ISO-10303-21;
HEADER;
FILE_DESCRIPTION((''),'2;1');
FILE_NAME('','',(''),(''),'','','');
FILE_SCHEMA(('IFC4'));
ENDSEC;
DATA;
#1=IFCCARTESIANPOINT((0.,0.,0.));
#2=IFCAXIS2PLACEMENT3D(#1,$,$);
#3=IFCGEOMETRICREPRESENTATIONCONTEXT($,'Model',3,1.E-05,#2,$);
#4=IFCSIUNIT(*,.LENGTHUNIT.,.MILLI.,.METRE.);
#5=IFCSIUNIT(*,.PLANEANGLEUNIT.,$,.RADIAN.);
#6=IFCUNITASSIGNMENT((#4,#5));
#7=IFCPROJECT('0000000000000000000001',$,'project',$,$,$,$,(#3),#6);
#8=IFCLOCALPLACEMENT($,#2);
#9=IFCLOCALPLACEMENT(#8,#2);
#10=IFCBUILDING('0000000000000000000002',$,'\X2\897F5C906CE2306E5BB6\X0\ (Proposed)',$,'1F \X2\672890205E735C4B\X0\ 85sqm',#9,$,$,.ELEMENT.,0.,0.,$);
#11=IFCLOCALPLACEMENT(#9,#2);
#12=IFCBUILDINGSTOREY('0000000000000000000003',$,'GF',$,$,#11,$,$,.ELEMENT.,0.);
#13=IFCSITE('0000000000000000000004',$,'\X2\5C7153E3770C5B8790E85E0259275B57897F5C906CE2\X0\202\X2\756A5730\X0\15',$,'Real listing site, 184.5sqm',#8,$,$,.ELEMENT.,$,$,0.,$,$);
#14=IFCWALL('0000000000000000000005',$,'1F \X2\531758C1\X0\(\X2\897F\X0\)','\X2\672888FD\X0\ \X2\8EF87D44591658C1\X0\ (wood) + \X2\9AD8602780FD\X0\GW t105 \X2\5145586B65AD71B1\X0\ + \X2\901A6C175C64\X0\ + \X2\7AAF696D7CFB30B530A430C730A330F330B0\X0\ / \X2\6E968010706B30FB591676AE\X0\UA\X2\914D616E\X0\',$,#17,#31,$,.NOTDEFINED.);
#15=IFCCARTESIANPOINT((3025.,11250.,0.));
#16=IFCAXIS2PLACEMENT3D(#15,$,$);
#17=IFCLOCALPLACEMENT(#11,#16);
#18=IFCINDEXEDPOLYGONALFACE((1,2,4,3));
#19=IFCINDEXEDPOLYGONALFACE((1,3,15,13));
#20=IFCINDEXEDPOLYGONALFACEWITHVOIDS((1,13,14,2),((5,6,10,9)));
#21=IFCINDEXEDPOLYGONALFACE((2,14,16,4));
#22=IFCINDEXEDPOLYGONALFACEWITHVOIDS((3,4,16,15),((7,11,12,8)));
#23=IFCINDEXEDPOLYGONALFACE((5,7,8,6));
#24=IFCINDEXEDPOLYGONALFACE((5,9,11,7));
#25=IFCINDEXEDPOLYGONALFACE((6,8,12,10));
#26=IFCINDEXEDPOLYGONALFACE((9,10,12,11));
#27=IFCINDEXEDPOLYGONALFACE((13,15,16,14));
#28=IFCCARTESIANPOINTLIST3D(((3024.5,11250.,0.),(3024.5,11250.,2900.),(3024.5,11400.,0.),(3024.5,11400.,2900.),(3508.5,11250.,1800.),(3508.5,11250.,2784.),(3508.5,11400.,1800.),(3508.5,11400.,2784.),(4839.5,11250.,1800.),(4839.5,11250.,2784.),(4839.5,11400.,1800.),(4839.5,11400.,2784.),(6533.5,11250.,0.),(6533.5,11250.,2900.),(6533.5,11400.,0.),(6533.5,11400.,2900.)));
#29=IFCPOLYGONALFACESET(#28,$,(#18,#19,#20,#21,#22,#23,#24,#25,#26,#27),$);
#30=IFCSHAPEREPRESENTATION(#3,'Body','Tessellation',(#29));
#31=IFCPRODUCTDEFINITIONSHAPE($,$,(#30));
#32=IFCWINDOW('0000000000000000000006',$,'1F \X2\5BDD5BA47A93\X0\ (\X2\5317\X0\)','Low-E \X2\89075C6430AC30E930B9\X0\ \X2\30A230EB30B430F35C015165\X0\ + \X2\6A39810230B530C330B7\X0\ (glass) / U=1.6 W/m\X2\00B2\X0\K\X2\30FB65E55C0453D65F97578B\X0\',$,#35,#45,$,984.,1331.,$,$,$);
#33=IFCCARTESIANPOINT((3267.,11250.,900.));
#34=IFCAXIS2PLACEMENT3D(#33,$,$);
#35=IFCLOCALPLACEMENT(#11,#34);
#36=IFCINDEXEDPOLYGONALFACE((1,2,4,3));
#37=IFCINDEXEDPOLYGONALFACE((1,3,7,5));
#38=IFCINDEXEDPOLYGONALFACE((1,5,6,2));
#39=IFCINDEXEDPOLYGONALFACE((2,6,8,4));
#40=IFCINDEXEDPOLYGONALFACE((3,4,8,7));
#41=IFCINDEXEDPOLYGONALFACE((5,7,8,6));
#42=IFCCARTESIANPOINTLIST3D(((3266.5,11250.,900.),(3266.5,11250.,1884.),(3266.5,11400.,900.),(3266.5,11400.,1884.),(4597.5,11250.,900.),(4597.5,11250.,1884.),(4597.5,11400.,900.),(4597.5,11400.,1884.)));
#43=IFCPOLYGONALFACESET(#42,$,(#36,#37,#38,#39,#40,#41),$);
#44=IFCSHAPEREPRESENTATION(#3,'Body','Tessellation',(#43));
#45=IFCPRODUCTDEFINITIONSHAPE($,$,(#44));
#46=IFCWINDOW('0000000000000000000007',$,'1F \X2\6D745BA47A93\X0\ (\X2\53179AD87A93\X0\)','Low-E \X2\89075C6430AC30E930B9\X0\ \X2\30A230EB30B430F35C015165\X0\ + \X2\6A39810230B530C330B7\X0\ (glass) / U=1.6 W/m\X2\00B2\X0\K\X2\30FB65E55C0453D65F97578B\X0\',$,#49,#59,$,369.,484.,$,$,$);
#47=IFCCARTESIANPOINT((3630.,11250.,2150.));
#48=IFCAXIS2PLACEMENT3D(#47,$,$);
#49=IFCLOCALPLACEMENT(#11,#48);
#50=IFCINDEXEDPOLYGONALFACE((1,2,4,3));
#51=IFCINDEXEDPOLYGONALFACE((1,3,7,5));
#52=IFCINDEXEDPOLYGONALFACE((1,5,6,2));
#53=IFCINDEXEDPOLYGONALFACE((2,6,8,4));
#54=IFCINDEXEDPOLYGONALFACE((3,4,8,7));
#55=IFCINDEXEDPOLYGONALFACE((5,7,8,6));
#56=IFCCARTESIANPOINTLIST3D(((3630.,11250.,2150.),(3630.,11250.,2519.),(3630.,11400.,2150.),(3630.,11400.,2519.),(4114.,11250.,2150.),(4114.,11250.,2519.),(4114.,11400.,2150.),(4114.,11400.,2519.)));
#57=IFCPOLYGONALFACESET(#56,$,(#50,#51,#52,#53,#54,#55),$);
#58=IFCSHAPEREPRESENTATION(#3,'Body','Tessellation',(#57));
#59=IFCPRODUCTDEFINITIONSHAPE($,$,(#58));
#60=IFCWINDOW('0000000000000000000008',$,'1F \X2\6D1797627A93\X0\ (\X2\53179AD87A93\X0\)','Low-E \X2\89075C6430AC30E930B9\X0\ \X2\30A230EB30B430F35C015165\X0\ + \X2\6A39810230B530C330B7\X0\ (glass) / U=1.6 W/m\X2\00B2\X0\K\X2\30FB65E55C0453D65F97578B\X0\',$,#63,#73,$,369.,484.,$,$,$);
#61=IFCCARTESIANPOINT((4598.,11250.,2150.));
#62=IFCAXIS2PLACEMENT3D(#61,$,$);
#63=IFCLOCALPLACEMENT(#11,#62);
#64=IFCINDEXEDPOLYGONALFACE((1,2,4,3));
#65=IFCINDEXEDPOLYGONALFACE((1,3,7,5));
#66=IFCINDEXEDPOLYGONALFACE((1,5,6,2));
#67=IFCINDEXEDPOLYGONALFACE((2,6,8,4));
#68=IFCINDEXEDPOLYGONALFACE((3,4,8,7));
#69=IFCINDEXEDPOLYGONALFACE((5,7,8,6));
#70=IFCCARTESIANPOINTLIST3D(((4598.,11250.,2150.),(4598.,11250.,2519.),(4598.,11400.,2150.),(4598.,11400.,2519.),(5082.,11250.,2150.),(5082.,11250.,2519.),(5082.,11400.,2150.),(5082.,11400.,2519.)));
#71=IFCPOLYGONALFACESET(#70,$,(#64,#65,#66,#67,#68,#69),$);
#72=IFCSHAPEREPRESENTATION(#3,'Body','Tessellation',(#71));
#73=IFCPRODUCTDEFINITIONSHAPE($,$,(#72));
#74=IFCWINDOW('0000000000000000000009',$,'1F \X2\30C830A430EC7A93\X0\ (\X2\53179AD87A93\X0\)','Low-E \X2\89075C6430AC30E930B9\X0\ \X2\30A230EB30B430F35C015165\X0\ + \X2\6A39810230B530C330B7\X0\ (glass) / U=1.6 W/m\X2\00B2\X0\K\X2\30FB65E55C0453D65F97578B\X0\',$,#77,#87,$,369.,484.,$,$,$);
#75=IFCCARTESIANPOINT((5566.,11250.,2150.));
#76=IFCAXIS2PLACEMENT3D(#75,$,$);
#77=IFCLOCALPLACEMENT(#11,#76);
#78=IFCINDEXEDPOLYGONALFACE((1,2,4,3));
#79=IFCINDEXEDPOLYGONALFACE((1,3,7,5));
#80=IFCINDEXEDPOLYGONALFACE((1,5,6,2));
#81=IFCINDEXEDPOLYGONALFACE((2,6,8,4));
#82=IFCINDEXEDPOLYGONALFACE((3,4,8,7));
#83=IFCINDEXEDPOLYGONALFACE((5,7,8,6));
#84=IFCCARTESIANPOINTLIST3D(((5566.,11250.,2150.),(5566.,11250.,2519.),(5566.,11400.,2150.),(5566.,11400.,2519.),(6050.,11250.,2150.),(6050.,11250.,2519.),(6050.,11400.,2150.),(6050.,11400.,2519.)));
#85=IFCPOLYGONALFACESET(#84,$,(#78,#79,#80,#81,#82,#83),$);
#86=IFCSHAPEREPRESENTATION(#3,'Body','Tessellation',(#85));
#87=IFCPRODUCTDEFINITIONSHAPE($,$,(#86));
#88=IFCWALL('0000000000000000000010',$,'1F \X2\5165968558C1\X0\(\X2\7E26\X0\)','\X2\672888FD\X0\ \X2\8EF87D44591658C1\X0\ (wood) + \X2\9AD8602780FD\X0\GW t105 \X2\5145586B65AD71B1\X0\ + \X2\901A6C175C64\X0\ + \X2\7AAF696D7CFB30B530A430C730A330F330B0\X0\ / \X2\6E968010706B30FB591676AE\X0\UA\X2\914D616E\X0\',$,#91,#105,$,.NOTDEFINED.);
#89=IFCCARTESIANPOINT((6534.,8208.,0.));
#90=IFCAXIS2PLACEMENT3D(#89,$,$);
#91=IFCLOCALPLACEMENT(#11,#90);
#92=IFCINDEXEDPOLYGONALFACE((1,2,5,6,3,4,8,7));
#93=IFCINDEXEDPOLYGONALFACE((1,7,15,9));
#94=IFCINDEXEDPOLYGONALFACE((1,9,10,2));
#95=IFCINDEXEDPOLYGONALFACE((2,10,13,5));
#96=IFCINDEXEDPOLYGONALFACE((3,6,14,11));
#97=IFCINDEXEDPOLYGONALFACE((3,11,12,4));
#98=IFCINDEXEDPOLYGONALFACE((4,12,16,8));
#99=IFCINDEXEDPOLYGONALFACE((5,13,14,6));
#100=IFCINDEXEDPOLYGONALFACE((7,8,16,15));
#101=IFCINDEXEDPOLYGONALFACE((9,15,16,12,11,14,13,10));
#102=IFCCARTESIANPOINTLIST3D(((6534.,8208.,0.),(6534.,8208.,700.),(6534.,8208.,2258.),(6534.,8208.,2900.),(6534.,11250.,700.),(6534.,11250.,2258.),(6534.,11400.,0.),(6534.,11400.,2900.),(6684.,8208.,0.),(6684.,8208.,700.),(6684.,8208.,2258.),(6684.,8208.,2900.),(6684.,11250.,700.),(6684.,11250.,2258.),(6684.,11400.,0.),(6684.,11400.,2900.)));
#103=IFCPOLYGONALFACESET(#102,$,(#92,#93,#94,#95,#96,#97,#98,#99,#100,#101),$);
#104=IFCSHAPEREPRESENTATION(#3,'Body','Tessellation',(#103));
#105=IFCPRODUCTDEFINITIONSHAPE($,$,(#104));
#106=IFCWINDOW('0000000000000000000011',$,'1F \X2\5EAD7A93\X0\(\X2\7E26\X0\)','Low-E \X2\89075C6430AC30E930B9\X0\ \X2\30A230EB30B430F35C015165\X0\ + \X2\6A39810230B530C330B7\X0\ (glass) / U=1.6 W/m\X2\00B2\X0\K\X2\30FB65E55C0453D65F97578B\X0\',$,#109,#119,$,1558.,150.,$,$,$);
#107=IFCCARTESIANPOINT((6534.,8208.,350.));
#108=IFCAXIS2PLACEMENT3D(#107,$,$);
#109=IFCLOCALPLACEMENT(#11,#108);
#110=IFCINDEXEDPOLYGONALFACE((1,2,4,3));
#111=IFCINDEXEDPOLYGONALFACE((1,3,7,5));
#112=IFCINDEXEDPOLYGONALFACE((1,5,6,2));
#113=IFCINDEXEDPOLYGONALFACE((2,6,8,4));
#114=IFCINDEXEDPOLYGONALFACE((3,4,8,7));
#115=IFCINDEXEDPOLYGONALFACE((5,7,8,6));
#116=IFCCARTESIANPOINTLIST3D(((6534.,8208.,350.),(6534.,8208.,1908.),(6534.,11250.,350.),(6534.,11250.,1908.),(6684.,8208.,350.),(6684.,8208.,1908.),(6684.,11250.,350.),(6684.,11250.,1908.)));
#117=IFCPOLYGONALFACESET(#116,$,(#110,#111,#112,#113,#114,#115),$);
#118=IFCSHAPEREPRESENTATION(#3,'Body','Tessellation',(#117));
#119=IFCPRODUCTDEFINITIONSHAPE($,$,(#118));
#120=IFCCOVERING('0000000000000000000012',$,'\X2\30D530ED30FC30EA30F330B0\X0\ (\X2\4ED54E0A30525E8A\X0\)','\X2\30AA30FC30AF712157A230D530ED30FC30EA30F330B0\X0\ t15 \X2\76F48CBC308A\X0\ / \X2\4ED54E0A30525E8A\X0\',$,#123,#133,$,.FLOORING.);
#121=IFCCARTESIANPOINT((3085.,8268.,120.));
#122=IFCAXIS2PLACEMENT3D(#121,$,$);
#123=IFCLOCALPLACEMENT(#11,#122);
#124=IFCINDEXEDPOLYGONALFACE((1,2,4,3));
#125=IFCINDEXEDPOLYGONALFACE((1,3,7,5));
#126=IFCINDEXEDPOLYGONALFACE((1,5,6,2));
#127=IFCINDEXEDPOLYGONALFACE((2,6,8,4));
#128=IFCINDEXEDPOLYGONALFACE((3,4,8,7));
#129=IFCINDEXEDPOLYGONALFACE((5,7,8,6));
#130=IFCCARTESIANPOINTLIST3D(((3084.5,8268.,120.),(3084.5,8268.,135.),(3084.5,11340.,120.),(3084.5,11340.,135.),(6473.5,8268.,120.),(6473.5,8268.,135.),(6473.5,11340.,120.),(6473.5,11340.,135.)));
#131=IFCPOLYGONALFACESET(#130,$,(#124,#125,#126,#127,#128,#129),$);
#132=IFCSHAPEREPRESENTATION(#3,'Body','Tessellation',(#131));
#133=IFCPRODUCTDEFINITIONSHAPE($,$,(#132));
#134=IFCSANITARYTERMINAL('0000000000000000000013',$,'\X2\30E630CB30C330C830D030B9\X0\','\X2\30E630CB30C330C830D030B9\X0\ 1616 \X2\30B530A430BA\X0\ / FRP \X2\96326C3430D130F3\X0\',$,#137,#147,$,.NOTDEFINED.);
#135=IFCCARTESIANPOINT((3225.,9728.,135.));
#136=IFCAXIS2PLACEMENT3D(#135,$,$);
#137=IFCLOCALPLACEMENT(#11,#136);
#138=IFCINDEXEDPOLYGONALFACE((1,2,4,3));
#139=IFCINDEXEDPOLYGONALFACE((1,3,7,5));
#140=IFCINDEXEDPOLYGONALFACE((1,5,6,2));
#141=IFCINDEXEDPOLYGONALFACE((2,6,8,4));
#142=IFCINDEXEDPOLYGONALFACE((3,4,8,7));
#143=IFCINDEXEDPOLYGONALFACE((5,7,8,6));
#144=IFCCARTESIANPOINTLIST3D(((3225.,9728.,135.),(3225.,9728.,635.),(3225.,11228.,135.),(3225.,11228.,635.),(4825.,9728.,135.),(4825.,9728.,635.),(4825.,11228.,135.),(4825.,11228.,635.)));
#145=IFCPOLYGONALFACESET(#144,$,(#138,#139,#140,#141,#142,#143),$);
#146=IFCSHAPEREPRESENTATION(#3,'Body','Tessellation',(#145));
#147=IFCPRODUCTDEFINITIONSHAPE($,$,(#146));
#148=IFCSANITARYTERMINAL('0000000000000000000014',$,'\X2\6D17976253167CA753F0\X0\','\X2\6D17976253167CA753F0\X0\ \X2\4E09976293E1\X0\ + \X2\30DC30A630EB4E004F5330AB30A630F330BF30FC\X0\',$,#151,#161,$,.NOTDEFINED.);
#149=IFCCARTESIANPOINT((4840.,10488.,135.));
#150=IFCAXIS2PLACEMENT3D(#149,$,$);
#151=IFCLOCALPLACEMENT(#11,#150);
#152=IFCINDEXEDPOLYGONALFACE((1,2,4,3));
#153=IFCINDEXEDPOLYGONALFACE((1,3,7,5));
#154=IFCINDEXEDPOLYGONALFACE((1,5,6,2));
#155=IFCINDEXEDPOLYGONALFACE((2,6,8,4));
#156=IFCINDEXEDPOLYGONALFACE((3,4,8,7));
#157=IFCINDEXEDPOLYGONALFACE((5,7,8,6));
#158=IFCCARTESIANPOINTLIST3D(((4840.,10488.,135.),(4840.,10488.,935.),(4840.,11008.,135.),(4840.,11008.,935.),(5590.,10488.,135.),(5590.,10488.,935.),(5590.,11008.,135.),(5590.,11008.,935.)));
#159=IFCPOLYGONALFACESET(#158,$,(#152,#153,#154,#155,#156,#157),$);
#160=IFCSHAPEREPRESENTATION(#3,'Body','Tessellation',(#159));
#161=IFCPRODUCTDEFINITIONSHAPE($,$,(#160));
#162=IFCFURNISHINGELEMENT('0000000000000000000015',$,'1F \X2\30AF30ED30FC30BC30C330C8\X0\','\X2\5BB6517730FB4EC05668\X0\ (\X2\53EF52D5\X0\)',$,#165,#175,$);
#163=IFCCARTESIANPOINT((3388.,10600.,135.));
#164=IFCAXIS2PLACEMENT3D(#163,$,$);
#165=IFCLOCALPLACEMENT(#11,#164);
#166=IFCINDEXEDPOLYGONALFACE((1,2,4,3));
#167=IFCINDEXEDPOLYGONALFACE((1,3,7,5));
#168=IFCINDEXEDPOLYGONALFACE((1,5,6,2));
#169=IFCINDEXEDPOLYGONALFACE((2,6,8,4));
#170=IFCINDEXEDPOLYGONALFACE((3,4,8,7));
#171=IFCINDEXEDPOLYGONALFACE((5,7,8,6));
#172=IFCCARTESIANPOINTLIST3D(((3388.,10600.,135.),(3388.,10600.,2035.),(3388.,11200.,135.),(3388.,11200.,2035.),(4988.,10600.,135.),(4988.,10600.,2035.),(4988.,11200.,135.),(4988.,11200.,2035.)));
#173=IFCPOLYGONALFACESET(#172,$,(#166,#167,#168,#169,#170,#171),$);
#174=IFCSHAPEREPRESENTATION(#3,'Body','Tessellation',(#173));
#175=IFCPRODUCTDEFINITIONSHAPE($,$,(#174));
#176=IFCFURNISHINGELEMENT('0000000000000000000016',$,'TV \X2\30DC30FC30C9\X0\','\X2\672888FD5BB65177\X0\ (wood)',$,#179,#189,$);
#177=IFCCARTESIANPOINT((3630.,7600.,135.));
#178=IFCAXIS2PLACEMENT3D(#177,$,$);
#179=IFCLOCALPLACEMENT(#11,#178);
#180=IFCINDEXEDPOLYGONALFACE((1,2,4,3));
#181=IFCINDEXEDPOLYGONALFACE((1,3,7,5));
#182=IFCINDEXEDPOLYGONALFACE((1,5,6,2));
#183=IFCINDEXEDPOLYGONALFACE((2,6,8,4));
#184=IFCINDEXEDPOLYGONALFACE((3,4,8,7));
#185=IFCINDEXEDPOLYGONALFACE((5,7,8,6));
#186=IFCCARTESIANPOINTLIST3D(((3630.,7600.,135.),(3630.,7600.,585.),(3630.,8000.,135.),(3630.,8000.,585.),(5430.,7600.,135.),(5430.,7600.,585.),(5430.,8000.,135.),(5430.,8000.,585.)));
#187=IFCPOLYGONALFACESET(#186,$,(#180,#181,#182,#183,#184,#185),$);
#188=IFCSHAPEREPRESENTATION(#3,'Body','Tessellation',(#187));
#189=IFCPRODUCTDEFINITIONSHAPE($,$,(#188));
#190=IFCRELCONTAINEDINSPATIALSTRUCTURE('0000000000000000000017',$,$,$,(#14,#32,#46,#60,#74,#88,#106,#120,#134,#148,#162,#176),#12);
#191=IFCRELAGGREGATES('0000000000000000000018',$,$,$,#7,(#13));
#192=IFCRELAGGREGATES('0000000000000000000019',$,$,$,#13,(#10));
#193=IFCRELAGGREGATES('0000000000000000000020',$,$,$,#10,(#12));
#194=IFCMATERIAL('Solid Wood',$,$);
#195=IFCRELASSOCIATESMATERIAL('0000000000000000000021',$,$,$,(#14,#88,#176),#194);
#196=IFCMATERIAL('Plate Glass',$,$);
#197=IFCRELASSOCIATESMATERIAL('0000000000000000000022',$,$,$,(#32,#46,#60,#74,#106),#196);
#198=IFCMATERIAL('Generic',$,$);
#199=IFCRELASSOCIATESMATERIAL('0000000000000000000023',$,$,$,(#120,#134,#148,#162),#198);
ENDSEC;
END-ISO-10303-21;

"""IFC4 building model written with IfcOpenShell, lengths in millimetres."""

from ifc_helpers import new_model, si_unit, frame, frame_2d, origin, place, context, project, spatial, rectangle, extrude, material, element, fill, save


model = new_model("IFC4")

# Units and contexts
model_context = context("Model", 3, precision=1e-05, world=origin())
ifc_project = project(units=[si_unit("LENGTHUNIT", "METRE", prefix="MILLI"), si_unit("PLANEANGLEUNIT", "RADIAN")], contexts=[model_context])

# Site, building, storey
site_placement = place(None, origin())
site = spatial("IfcSite", under=ifc_project, at=site_placement, Name="山口県宇部市大字西岐波202番地15", ObjectType="Real listing site, 184.5sqm", CompositionType="ELEMENT", RefElevation=0.0)
building_placement = place(site_placement, origin())
building = spatial("IfcBuilding", under=site, at=building_placement, Name="西岐波の家 (Proposed)", ObjectType="1F 木造平屋 85sqm", CompositionType="ELEMENT", ElevationOfRefHeight=0.0, ElevationOfTerrain=0.0)
storey_placement = place(building_placement, origin())
storey = spatial("IfcBuildingStorey", under=building, at=storey_placement, Name="GF", CompositionType="ELEMENT", Elevation=0.0)

# Shared definitions
ifc_material_1 = material(Name="Solid Wood")

# Wall, openings, windows
wall_1_placement = place(storey_placement, frame((3025.0, 11250.0, 0.0)))
wall_1 = element("IfcWall", 1, at=wall_1_placement, inside=storey, material=ifc_material_1, Name="1F 北壁(西)", Description="木製 軸組外壁 (wood) + 高性能GW t105 充填断熱 + 通気層 + 窯業系サイディング / 準耐火・外皮UA配慮", PredefinedType="NOTDEFINED", context=model_context, shape_type="SweptSolid", body=[
    extrude(rectangle(XDim=3509.0, YDim=150.0, at=frame_2d((1754.0, 75.0))), frame((3025.0, 11250.0, 0.0)), (0.0, 0.0, 1.0), 2900.0),
])
opening_1_placement = place(storey_placement, frame((3267.0, 11250.0, 900.0)))
opening_1 = element("IfcOpeningElement", 2, at=opening_1_placement, cuts=wall_1, PredefinedType="NOTDEFINED", context=model_context, shape_type="SweptSolid", body=[
    extrude(rectangle(XDim=1331.0, YDim=150.0, at=frame_2d((665.0, 75.0))), frame((3267.0, 11250.0, 900.0)), (0.0, 0.0, 1.0), 984.0),
])
opening_2_placement = place(storey_placement, frame((3630.0, 11250.0, 2150.0)))
opening_2 = element("IfcOpeningElement", 3, at=opening_2_placement, cuts=wall_1, PredefinedType="NOTDEFINED", context=model_context, shape_type="SweptSolid", body=[
    extrude(rectangle(XDim=484.0, YDim=150.0, at=frame_2d((242.0, 75.0))), frame((3630.0, 11250.0, 2150.0)), (0.0, 0.0, 1.0), 369.0),
])
opening_3_placement = place(storey_placement, frame((4598.0, 11250.0, 2150.0)))
opening_3 = element("IfcOpeningElement", 4, at=opening_3_placement, cuts=wall_1, PredefinedType="NOTDEFINED", context=model_context, shape_type="SweptSolid", body=[
    extrude(rectangle(XDim=484.0, YDim=150.0, at=frame_2d((242.0, 75.0))), frame((4598.0, 11250.0, 2150.0)), (0.0, 0.0, 1.0), 369.0),
])
opening_4_placement = place(storey_placement, frame((5566.0, 11250.0, 2150.0)))
opening_4 = element("IfcOpeningElement", 5, at=opening_4_placement, cuts=wall_1, PredefinedType="NOTDEFINED", context=model_context, shape_type="SweptSolid", body=[
    extrude(rectangle(XDim=484.0, YDim=150.0, at=frame_2d((242.0, 75.0))), frame((5566.0, 11250.0, 2150.0)), (0.0, 0.0, 1.0), 369.0),
])
ifc_material_2 = material(Name="Plate Glass")
window_1_placement = place(storey_placement, frame((3267.0, 11250.0, 900.0)))
window_1 = element("IfcWindow", 6, at=window_1_placement, inside=storey, material=ifc_material_2, Name="1F 寝室窓 (北)", Description="Low-E 複層ガラス アルゴン封入 + 樹脂サッシ (glass) / U=1.6 W/m²K・日射取得型", OverallHeight=984.0, OverallWidth=1331.0, context=model_context, shape_type="SweptSolid", body=[
    extrude(rectangle(XDim=1331.0, YDim=150.0, at=frame_2d((665.0, 75.0))), frame((3267.0, 11250.0, 900.0)), (0.0, 0.0, 1.0), 984.0),
])
fill(opening_1, window_1)
window_2_placement = place(storey_placement, frame((3630.0, 11250.0, 2150.0)))
window_2 = element("IfcWindow", 7, at=window_2_placement, inside=storey, material=ifc_material_2, Name="1F 浴室窓 (北高窓)", Description="Low-E 複層ガラス アルゴン封入 + 樹脂サッシ (glass) / U=1.6 W/m²K・日射取得型", OverallHeight=369.0, OverallWidth=484.0, context=model_context, shape_type="SweptSolid", body=[
    extrude(rectangle(XDim=484.0, YDim=150.0, at=frame_2d((242.0, 75.0))), frame((3630.0, 11250.0, 2150.0)), (0.0, 0.0, 1.0), 369.0),
])
fill(opening_2, window_2)
window_3_placement = place(storey_placement, frame((4598.0, 11250.0, 2150.0)))
window_3 = element("IfcWindow", 8, at=window_3_placement, inside=storey, material=ifc_material_2, Name="1F 洗面窓 (北高窓)", Description="Low-E 複層ガラス アルゴン封入 + 樹脂サッシ (glass) / U=1.6 W/m²K・日射取得型", OverallHeight=369.0, OverallWidth=484.0, context=model_context, shape_type="SweptSolid", body=[
    extrude(rectangle(XDim=484.0, YDim=150.0, at=frame_2d((242.0, 75.0))), frame((4598.0, 11250.0, 2150.0)), (0.0, 0.0, 1.0), 369.0),
])
fill(opening_3, window_3)
window_4_placement = place(storey_placement, frame((5566.0, 11250.0, 2150.0)))
window_4 = element("IfcWindow", 9, at=window_4_placement, inside=storey, material=ifc_material_2, Name="1F トイレ窓 (北高窓)", Description="Low-E 複層ガラス アルゴン封入 + 樹脂サッシ (glass) / U=1.6 W/m²K・日射取得型", OverallHeight=369.0, OverallWidth=484.0, context=model_context, shape_type="SweptSolid", body=[
    extrude(rectangle(XDim=484.0, YDim=150.0, at=frame_2d((242.0, 75.0))), frame((5566.0, 11250.0, 2150.0)), (0.0, 0.0, 1.0), 369.0),
])
fill(opening_4, window_4)

# Wall, opening, window
wall_2_placement = place(storey_placement, frame((6534.0, 8208.0, 0.0)))
wall_2 = element("IfcWall", 10, at=wall_2_placement, inside=storey, material=ifc_material_1, Name="1F 入隅壁(縦)", Description="木製 軸組外壁 (wood) + 高性能GW t105 充填断熱 + 通気層 + 窯業系サイディング / 準耐火・外皮UA配慮", PredefinedType="NOTDEFINED", context=model_context, shape_type="SweptSolid", body=[
    extrude(rectangle(XDim=150.0, YDim=3192.0, at=frame_2d((75.0, 1596.0))), frame((6534.0, 8208.0, 0.0)), (0.0, 0.0, 1.0), 2900.0),
])
opening_5_placement = place(storey_placement, frame((6534.0, 8208.0, 350.0)))
opening_5 = element("IfcOpeningElement", 11, at=opening_5_placement, cuts=wall_2, PredefinedType="NOTDEFINED", context=model_context, shape_type="SweptSolid", body=[
    extrude(rectangle(XDim=150.0, YDim=3042.0, at=frame_2d((75.0, 1521.0))), frame((6534.0, 8208.0, 350.0)), (0.0, 0.0, 1.0), 1558.0),
])
window_5_placement = place(storey_placement, frame((6534.0, 8208.0, 350.0)))
window_5 = element("IfcWindow", 12, at=window_5_placement, inside=storey, material=ifc_material_2, Name="1F 庭窓(縦)", Description="Low-E 複層ガラス アルゴン封入 + 樹脂サッシ (glass) / U=1.6 W/m²K・日射取得型", OverallHeight=1558.0, OverallWidth=150.0, context=model_context, shape_type="SweptSolid", body=[
    extrude(rectangle(XDim=150.0, YDim=3042.0, at=frame_2d((75.0, 1521.0))), frame((6534.0, 8208.0, 350.0)), (0.0, 0.0, 1.0), 1558.0),
])
fill(opening_5, window_5)

# Covering
ifc_material_3 = material(Name="Generic")
covering_placement = place(storey_placement, frame((3085.0, 8268.0, 120.0)))
element("IfcCovering", 13, at=covering_placement, inside=storey, material=ifc_material_3, Name="フローリング (仕上げ床)", Description="オーク無垢フローリング t15 直貼り / 仕上げ床", PredefinedType="FLOORING", context=model_context, shape_type="SweptSolid", body=[
    extrude(rectangle(XDim=3389.0, YDim=3072.0, at=frame_2d((1694.0, 1536.0))), frame((3085.0, 8268.0, 120.0)), (0.0, 0.0, 1.0), 15.0),
])

# Sanitary terminals
sanitary_terminal_1_placement = place(storey_placement, frame((3225.0, 9728.0, 135.0)))
element("IfcSanitaryTerminal", 14, at=sanitary_terminal_1_placement, inside=storey, material=ifc_material_3, Name="ユニットバス", Description="ユニットバス 1616 サイズ / FRP 防水パン", PredefinedType="NOTDEFINED", context=model_context, shape_type="SweptSolid", body=[
    extrude(rectangle(XDim=1600.0, YDim=1500.0, at=frame_2d((800.0, 750.0))), frame((3225.0, 9728.0, 135.0)), (0.0, 0.0, 1.0), 500.0),
])
sanitary_terminal_2_placement = place(storey_placement, frame((4840.0, 10488.0, 135.0)))
element("IfcSanitaryTerminal", 15, at=sanitary_terminal_2_placement, inside=storey, material=ifc_material_3, Name="洗面化粧台", Description="洗面化粧台 三面鏡 + ボウル一体カウンター", PredefinedType="NOTDEFINED", context=model_context, shape_type="SweptSolid", body=[
    extrude(rectangle(XDim=750.0, YDim=520.0, at=frame_2d((375.0, 260.0))), frame((4840.0, 10488.0, 135.0)), (0.0, 0.0, 1.0), 800.0),
])

# Furnishing elements
furnishing_1_placement = place(storey_placement, frame((3388.0, 10600.0, 135.0)))
element("IfcFurnishingElement", 16, at=furnishing_1_placement, inside=storey, material=ifc_material_3, Name="1F クローゼット", Description="家具・什器 (可動)", context=model_context, shape_type="SweptSolid", body=[
    extrude(rectangle(XDim=1600.0, YDim=600.0, at=frame_2d((800.0, 300.0))), frame((3388.0, 10600.0, 135.0)), (0.0, 0.0, 1.0), 1900.0),
])
furnishing_2_placement = place(storey_placement, frame((3630.0, 7600.0, 135.0)))
element("IfcFurnishingElement", 17, at=furnishing_2_placement, inside=storey, material=ifc_material_1, Name="TV ボード", Description="木製家具 (wood)", context=model_context, shape_type="SweptSolid", body=[
    extrude(rectangle(XDim=1800.0, YDim=400.0, at=frame_2d((900.0, 200.0))), frame((3630.0, 7600.0, 135.0)), (0.0, 0.0, 1.0), 450.0),
])

save(model, "model.ifc")
